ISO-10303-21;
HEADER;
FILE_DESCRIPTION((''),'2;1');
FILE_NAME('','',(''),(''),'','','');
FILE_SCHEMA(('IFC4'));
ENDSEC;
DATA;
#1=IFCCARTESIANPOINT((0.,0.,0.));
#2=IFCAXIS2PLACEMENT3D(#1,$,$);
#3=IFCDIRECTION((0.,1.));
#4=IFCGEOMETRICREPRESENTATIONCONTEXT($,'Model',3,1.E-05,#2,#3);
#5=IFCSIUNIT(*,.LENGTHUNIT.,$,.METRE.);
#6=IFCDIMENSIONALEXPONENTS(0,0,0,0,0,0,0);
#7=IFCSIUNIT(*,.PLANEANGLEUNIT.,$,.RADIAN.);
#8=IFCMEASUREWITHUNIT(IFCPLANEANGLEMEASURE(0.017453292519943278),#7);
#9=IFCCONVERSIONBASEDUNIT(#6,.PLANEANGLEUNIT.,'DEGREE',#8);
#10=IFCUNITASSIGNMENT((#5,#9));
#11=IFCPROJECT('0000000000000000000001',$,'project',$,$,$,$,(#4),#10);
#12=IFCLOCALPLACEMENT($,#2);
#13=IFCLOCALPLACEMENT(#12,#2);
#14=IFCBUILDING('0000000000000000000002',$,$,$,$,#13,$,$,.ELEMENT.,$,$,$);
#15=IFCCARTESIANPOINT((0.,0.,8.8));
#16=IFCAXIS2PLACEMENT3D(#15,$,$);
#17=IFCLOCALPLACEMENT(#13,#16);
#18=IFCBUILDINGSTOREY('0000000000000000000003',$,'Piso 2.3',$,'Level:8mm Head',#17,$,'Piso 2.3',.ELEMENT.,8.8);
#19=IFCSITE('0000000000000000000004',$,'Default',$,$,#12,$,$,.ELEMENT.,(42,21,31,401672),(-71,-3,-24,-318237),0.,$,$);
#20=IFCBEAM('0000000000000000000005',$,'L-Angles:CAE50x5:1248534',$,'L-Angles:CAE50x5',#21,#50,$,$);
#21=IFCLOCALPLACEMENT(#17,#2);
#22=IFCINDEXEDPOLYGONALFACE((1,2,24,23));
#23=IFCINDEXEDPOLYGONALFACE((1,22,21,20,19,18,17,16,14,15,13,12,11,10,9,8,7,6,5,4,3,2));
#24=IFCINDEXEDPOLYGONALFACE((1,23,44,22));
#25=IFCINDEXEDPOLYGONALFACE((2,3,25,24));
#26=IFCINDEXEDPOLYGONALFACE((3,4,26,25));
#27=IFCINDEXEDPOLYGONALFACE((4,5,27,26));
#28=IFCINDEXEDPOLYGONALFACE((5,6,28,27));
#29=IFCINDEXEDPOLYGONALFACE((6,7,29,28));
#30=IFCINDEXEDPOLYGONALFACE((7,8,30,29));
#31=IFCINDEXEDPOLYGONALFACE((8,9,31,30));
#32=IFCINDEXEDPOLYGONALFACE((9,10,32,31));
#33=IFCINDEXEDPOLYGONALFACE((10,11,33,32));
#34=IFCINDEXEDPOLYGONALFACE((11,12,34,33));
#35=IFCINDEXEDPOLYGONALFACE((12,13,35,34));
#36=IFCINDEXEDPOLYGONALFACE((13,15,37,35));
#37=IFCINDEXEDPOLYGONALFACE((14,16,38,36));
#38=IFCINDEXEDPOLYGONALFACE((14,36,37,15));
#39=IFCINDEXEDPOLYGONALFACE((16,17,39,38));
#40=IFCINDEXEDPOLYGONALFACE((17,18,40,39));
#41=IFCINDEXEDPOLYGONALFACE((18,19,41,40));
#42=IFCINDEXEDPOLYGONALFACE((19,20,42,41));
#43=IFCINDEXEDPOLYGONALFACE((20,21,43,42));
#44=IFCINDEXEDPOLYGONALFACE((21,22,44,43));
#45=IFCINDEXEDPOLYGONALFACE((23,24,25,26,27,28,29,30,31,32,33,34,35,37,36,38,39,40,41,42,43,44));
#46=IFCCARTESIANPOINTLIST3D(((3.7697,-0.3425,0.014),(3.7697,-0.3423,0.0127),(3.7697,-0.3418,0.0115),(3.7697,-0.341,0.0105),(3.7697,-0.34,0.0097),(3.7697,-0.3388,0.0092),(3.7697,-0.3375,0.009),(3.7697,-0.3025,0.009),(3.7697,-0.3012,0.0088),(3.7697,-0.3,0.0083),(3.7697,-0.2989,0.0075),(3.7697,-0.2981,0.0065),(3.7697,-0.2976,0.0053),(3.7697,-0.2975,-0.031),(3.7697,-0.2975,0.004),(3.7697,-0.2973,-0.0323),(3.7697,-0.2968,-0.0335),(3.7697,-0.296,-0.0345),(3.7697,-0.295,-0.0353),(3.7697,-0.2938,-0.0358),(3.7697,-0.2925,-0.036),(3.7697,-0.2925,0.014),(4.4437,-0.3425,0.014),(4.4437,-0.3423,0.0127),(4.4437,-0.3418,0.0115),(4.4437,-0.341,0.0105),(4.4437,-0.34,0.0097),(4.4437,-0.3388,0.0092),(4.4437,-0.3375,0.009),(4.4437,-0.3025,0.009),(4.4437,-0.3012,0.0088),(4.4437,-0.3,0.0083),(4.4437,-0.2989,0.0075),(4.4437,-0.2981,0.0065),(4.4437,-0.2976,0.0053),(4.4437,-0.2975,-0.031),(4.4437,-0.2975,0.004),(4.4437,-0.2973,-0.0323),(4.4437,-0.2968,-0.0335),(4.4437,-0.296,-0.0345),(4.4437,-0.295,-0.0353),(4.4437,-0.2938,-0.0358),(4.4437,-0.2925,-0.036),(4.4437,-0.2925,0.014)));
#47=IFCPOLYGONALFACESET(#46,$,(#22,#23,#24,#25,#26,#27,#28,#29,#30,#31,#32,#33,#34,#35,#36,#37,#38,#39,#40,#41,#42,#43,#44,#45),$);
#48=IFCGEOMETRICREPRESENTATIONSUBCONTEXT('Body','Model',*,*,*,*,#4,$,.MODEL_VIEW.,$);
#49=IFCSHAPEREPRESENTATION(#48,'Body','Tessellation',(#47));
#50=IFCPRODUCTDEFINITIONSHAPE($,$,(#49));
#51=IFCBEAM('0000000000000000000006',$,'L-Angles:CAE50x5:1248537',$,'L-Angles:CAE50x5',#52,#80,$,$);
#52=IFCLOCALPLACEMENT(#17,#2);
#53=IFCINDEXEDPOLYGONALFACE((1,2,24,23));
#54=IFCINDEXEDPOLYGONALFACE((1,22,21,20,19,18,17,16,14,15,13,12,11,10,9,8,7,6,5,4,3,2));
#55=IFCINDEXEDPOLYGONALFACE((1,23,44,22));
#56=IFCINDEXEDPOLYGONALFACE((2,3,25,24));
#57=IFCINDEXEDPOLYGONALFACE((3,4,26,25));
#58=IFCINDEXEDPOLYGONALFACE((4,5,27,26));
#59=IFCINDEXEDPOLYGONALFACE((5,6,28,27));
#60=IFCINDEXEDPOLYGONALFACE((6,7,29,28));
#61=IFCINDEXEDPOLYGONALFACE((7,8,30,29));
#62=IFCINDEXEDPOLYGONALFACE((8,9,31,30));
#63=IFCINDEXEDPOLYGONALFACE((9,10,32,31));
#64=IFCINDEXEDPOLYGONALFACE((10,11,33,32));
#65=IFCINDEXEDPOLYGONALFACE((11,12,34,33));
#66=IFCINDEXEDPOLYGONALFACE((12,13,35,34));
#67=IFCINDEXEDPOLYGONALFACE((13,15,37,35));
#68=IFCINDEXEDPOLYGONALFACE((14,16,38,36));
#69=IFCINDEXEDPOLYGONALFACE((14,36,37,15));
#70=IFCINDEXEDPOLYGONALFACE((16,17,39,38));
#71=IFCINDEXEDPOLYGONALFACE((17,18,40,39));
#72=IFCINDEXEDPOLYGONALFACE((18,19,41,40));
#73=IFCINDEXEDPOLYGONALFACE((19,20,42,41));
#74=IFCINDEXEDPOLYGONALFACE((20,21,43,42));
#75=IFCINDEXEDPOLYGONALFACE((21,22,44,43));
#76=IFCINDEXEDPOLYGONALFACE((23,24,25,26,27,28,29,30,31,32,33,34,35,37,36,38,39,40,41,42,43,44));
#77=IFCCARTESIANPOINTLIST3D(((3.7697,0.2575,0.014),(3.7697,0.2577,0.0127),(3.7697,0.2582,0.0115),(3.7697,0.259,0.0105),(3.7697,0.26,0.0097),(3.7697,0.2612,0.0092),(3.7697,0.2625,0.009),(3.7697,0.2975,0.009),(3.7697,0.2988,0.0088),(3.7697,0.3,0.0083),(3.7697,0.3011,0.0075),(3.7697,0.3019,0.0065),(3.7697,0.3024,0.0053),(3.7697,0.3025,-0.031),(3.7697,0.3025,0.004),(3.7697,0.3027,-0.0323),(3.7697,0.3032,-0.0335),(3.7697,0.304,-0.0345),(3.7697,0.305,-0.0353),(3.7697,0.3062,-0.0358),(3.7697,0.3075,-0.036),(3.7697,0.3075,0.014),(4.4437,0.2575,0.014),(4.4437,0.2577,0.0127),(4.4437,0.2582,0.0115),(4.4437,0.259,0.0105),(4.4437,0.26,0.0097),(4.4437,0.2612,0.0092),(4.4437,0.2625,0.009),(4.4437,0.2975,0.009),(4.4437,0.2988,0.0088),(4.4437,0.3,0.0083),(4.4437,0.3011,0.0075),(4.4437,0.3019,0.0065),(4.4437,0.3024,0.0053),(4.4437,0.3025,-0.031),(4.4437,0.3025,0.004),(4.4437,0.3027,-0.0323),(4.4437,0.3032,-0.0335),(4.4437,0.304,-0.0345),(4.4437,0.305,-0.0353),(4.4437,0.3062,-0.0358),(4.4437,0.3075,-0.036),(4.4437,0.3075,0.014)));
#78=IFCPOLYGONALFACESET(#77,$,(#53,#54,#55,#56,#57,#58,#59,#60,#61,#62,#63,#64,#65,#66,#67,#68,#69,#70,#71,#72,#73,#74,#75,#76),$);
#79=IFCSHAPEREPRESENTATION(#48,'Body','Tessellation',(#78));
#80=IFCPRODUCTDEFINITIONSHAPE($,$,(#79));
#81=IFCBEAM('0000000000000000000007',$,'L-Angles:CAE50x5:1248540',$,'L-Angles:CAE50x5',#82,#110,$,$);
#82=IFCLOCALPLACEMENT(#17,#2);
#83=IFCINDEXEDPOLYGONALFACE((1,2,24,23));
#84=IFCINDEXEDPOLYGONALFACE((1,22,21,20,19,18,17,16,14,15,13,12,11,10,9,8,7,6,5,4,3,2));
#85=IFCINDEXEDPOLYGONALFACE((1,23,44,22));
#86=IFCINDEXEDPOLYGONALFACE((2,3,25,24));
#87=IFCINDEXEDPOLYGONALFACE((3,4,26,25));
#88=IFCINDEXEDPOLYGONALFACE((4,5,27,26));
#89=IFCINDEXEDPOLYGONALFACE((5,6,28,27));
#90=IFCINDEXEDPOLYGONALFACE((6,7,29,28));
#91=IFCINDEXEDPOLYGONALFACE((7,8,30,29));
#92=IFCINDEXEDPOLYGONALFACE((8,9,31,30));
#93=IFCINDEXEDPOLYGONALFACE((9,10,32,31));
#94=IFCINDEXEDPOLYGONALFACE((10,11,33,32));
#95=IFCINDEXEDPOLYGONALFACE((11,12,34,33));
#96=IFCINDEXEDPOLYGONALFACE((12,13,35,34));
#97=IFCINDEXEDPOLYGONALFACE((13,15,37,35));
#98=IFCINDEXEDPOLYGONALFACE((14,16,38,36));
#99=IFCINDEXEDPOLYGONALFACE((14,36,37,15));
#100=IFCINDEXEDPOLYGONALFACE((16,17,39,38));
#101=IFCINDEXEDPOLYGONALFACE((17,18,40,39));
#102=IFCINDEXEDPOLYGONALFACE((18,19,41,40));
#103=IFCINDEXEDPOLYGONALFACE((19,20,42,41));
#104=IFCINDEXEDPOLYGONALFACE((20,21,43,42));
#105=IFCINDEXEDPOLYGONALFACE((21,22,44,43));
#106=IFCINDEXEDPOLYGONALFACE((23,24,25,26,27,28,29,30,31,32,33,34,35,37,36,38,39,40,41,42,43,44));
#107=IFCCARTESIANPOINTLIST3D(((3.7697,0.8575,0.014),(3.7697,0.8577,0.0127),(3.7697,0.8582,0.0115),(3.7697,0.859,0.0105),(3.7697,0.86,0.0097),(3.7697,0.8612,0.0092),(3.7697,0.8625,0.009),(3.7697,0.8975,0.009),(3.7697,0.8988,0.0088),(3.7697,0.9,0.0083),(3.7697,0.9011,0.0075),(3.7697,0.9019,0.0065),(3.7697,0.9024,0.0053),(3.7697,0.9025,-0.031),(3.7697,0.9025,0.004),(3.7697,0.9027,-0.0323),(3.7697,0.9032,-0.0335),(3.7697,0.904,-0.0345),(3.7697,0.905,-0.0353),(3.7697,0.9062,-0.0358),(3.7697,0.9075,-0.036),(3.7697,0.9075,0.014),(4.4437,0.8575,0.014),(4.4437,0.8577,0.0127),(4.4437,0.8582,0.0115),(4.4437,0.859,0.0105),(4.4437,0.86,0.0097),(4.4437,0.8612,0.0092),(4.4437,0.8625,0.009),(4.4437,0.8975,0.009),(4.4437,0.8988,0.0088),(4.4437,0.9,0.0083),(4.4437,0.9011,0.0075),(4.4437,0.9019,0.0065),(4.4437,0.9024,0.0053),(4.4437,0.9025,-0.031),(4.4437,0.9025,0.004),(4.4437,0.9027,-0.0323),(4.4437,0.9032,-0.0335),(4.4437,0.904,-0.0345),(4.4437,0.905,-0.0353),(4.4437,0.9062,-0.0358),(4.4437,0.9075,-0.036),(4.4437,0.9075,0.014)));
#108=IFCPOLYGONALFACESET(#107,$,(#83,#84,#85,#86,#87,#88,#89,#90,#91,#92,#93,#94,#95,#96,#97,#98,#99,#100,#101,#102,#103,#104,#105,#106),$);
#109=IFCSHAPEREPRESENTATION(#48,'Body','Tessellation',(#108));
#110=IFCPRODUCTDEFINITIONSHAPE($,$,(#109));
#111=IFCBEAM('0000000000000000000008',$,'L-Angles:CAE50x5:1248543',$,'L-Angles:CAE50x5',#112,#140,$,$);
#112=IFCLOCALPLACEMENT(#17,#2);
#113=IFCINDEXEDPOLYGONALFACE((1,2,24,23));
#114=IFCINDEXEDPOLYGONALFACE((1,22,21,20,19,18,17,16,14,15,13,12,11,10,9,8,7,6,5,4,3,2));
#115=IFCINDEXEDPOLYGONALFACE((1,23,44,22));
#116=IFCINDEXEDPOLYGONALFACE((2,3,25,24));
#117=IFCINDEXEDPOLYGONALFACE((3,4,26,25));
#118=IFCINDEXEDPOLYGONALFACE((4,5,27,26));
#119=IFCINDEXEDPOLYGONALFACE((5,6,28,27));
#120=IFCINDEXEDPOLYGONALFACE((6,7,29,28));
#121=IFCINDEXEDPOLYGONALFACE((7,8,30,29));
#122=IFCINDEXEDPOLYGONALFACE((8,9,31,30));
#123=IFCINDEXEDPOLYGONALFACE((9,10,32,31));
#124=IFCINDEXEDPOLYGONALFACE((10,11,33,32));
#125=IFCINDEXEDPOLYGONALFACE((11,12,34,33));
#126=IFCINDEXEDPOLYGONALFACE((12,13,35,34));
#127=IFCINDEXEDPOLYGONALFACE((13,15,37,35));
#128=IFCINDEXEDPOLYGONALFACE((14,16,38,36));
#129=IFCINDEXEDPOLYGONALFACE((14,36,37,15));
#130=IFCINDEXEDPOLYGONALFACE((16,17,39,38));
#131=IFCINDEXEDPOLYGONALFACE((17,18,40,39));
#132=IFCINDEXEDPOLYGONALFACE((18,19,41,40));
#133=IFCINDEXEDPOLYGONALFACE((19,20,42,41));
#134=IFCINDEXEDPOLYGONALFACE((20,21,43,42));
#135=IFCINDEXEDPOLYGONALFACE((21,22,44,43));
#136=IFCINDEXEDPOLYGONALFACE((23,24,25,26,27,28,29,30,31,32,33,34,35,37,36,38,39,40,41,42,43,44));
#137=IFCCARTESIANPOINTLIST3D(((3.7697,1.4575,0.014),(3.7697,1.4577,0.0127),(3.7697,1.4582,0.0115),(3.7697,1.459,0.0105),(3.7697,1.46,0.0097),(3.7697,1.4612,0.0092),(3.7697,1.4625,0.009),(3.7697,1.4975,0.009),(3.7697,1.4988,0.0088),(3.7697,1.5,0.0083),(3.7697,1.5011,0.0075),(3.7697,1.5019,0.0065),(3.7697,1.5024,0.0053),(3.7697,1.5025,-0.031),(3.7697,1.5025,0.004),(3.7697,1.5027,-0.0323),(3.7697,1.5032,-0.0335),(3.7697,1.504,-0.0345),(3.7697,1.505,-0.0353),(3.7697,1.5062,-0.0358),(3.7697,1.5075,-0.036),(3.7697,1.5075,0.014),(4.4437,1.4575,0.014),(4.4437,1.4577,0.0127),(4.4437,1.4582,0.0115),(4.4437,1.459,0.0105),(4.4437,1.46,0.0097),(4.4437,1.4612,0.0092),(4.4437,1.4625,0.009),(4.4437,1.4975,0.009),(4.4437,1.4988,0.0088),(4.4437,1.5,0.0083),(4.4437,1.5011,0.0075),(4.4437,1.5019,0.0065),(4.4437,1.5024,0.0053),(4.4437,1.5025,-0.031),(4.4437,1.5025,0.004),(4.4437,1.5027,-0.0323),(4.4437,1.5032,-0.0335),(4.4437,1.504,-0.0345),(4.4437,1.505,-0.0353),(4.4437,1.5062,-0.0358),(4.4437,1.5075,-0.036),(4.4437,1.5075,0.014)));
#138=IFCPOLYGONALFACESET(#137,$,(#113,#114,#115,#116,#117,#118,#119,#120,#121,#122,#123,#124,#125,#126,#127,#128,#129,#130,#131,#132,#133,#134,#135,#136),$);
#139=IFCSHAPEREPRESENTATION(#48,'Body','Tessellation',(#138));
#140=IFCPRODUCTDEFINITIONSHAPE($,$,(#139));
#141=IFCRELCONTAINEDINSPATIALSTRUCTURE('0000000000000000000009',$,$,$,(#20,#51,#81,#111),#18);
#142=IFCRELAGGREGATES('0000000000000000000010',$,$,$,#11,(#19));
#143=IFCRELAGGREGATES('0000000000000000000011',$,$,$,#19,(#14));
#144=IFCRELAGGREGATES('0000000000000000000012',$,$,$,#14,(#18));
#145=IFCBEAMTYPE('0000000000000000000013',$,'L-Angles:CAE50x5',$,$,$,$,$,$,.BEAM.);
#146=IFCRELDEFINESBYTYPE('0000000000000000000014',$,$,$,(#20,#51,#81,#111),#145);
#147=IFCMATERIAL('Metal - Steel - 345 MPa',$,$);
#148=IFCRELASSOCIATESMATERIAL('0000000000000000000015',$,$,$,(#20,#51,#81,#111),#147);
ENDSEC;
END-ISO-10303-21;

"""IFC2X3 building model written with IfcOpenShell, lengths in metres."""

from ifc_helpers import new_model, entity, si_unit, converted_unit, direction, frame, frame_2d, origin, place, context, subcontext, project, spatial, polyline, circle_curve, parameter, trimmed, segment, composite_curve, outline, extrude, material, type_object, element, save


model = new_model("IFC2X3")

# Units and contexts
model_context = context("Model", 3, precision=1e-05, world=origin(), true_north=direction((0.0, 1.0)))
body_context = subcontext(model_context, "Body", "Model", "MODEL_VIEW")
ifc_project = project(units=[si_unit("LENGTHUNIT", "METRE"), converted_unit("PLANEANGLEUNIT", "DEGREE", entity("IfcPlaneAngleMeasure", 0.017453292519943278), si_unit("PLANEANGLEUNIT", "RADIAN"), dimensions=[0, 0, 0, 0, 0, 0, 0])], contexts=[model_context])

# Site, building, storey
site_placement = place(None, origin())
site = spatial("IfcSite", under=ifc_project, at=site_placement, Name="Default", CompositionType="ELEMENT", RefLatitude=(42, 21, 31, 401672), RefLongitude=(-71, -3, -24, -318237), RefElevation=0.0)
building_placement = place(site_placement, origin())
building = spatial("IfcBuilding", under=site, at=building_placement, CompositionType="ELEMENT")
storey_placement = place(building_placement, frame((0.0, 0.0, 8.8)))
storey = spatial("IfcBuildingStorey", under=building, at=storey_placement, Name="Piso 2.3", ObjectType="Level:8mm Head", LongName="Piso 2.3", CompositionType="ELEMENT", Elevation=8.8)

# Beams
ifc_material_1 = material(Name="Metal - Steel - 345 MPa")
beam_type_1 = type_object("IfcBeamType", Name="L-Angles:CAE50x5", PredefinedType="BEAM")
beam_1_placement = place(storey_placement, frame((3.7067, -0.3065, 0.0)))
element("IfcBeam", 1, at=beam_1_placement, inside=storey, type_object=beam_type_1, material=ifc_material_1, Name="L-Angles:CAE50x5:1248534", ObjectType="L-Angles:CAE50x5", context=body_context, shape_type="SweptSolid", body=[
    extrude(outline(composite_curve([segment(polyline([(-0.0336, -0.0164), (0.0164, -0.0164)]), True, "CONTINUOUS"), segment(polyline([(0.0164, -0.0164), (0.0164, 0.0336)]), True, "CONTINUOUS"), segment(trimmed(circle_curve(frame_2d((0.0164, 0.0286), x_axis=(0.0, 1.0)), 0.005), [parameter(0.0)], [parameter(90.0)], True, "PARAMETER"), True, "CONTINUOUS"), segment(polyline([(0.0114, 0.0286), (0.0114, -0.0064)]), True, "CONTINUOUS"), segment(trimmed(circle_curve(frame_2d((0.0064, -0.0064), x_axis=(1.0, 0.0)), 0.005), [parameter(270.0)], [parameter(0.0)], True, "PARAMETER"), False, "CONTINUOUS"), segment(polyline([(0.0064, -0.0114), (-0.0286, -0.0114)]), True, "CONTINUOUS"), segment(trimmed(circle_curve(frame_2d((-0.0286, -0.0164), x_axis=(0.0, 1.0)), 0.005), [parameter(0.0)], [parameter(90.0)], True, "PARAMETER"), True, "CONTINUOUS")], self_intersect=False)), frame((0.063, -0.0024, -0.0024), z_axis=(1.0, 0.0, 0.0), x_axis=(0.0, 0.0, 1.0)), (0.0, 0.0, 1.0), 0.674),
])
beam_2_placement = place(storey_placement, frame((3.7067, 0.2935, 0.0)))
element("IfcBeam", 2, at=beam_2_placement, inside=storey, type_object=beam_type_1, material=ifc_material_1, Name="L-Angles:CAE50x5:1248537", ObjectType="L-Angles:CAE50x5", context=body_context, shape_type="SweptSolid", body=[
    extrude(outline(composite_curve([segment(polyline([(-0.0336, -0.0164), (0.0164, -0.0164)]), True, "CONTINUOUS"), segment(polyline([(0.0164, -0.0164), (0.0164, 0.0336)]), True, "CONTINUOUS"), segment(trimmed(circle_curve(frame_2d((0.0164, 0.0286), x_axis=(0.0, 1.0)), 0.005), [parameter(0.0)], [parameter(90.0)], True, "PARAMETER"), True, "CONTINUOUS"), segment(polyline([(0.0114, 0.0286), (0.0114, -0.0064)]), True, "CONTINUOUS"), segment(trimmed(circle_curve(frame_2d((0.0064, -0.0064), x_axis=(1.0, 0.0)), 0.005), [parameter(270.0)], [parameter(0.0)], True, "PARAMETER"), False, "CONTINUOUS"), segment(polyline([(0.0064, -0.0114), (-0.0286, -0.0114)]), True, "CONTINUOUS"), segment(trimmed(circle_curve(frame_2d((-0.0286, -0.0164), x_axis=(0.0, 1.0)), 0.005), [parameter(0.0)], [parameter(90.0)], True, "PARAMETER"), True, "CONTINUOUS")], self_intersect=False)), frame((0.063, -0.0024, -0.0024), z_axis=(1.0, 0.0, 0.0), x_axis=(0.0, 0.0, 1.0)), (0.0, 0.0, 1.0), 0.674),
])
beam_3_placement = place(storey_placement, frame((3.7067, 0.8935, 0.0)))
element("IfcBeam", 3, at=beam_3_placement, inside=storey, type_object=beam_type_1, material=ifc_material_1, Name="L-Angles:CAE50x5:1248540", ObjectType="L-Angles:CAE50x5", context=body_context, shape_type="SweptSolid", body=[
    extrude(outline(composite_curve([segment(polyline([(-0.0336, -0.0164), (0.0164, -0.0164)]), True, "CONTINUOUS"), segment(polyline([(0.0164, -0.0164), (0.0164, 0.0336)]), True, "CONTINUOUS"), segment(trimmed(circle_curve(frame_2d((0.0164, 0.0286), x_axis=(0.0, 1.0)), 0.005), [parameter(0.0)], [parameter(90.0)], True, "PARAMETER"), True, "CONTINUOUS"), segment(polyline([(0.0114, 0.0286), (0.0114, -0.0064)]), True, "CONTINUOUS"), segment(trimmed(circle_curve(frame_2d((0.0064, -0.0064), x_axis=(1.0, 0.0)), 0.005), [parameter(270.0)], [parameter(0.0)], True, "PARAMETER"), False, "CONTINUOUS"), segment(polyline([(0.0064, -0.0114), (-0.0286, -0.0114)]), True, "CONTINUOUS"), segment(trimmed(circle_curve(frame_2d((-0.0286, -0.0164), x_axis=(0.0, 1.0)), 0.005), [parameter(0.0)], [parameter(90.0)], True, "PARAMETER"), True, "CONTINUOUS")], self_intersect=False)), frame((0.063, -0.0024, -0.0024), z_axis=(1.0, 0.0, 0.0), x_axis=(0.0, 0.0, 1.0)), (0.0, 0.0, 1.0), 0.674),
])
beam_4_placement = place(storey_placement, frame((3.7067, 1.4935, 0.0)))
element("IfcBeam", 4, at=beam_4_placement, inside=storey, type_object=beam_type_1, material=ifc_material_1, Name="L-Angles:CAE50x5:1248543", ObjectType="L-Angles:CAE50x5", context=body_context, shape_type="SweptSolid", body=[
    extrude(outline(composite_curve([segment(polyline([(-0.0336, -0.0164), (0.0164, -0.0164)]), True, "CONTINUOUS"), segment(polyline([(0.0164, -0.0164), (0.0164, 0.0336)]), True, "CONTINUOUS"), segment(trimmed(circle_curve(frame_2d((0.0164, 0.0286), x_axis=(0.0, 1.0)), 0.005), [parameter(0.0)], [parameter(90.0)], True, "PARAMETER"), True, "CONTINUOUS"), segment(polyline([(0.0114, 0.0286), (0.0114, -0.0064)]), True, "CONTINUOUS"), segment(trimmed(circle_curve(frame_2d((0.0064, -0.0064), x_axis=(1.0, 0.0)), 0.005), [parameter(270.0)], [parameter(0.0)], True, "PARAMETER"), False, "CONTINUOUS"), segment(polyline([(0.0064, -0.0114), (-0.0286, -0.0114)]), True, "CONTINUOUS"), segment(trimmed(circle_curve(frame_2d((-0.0286, -0.0164), x_axis=(0.0, 1.0)), 0.005), [parameter(0.0)], [parameter(90.0)], True, "PARAMETER"), True, "CONTINUOUS")], self_intersect=False)), frame((0.063, -0.0024, -0.0024), z_axis=(1.0, 0.0, 0.0), x_axis=(0.0, 0.0, 1.0)), (0.0, 0.0, 1.0), 0.674),
])

save(model, "model.ifc")
